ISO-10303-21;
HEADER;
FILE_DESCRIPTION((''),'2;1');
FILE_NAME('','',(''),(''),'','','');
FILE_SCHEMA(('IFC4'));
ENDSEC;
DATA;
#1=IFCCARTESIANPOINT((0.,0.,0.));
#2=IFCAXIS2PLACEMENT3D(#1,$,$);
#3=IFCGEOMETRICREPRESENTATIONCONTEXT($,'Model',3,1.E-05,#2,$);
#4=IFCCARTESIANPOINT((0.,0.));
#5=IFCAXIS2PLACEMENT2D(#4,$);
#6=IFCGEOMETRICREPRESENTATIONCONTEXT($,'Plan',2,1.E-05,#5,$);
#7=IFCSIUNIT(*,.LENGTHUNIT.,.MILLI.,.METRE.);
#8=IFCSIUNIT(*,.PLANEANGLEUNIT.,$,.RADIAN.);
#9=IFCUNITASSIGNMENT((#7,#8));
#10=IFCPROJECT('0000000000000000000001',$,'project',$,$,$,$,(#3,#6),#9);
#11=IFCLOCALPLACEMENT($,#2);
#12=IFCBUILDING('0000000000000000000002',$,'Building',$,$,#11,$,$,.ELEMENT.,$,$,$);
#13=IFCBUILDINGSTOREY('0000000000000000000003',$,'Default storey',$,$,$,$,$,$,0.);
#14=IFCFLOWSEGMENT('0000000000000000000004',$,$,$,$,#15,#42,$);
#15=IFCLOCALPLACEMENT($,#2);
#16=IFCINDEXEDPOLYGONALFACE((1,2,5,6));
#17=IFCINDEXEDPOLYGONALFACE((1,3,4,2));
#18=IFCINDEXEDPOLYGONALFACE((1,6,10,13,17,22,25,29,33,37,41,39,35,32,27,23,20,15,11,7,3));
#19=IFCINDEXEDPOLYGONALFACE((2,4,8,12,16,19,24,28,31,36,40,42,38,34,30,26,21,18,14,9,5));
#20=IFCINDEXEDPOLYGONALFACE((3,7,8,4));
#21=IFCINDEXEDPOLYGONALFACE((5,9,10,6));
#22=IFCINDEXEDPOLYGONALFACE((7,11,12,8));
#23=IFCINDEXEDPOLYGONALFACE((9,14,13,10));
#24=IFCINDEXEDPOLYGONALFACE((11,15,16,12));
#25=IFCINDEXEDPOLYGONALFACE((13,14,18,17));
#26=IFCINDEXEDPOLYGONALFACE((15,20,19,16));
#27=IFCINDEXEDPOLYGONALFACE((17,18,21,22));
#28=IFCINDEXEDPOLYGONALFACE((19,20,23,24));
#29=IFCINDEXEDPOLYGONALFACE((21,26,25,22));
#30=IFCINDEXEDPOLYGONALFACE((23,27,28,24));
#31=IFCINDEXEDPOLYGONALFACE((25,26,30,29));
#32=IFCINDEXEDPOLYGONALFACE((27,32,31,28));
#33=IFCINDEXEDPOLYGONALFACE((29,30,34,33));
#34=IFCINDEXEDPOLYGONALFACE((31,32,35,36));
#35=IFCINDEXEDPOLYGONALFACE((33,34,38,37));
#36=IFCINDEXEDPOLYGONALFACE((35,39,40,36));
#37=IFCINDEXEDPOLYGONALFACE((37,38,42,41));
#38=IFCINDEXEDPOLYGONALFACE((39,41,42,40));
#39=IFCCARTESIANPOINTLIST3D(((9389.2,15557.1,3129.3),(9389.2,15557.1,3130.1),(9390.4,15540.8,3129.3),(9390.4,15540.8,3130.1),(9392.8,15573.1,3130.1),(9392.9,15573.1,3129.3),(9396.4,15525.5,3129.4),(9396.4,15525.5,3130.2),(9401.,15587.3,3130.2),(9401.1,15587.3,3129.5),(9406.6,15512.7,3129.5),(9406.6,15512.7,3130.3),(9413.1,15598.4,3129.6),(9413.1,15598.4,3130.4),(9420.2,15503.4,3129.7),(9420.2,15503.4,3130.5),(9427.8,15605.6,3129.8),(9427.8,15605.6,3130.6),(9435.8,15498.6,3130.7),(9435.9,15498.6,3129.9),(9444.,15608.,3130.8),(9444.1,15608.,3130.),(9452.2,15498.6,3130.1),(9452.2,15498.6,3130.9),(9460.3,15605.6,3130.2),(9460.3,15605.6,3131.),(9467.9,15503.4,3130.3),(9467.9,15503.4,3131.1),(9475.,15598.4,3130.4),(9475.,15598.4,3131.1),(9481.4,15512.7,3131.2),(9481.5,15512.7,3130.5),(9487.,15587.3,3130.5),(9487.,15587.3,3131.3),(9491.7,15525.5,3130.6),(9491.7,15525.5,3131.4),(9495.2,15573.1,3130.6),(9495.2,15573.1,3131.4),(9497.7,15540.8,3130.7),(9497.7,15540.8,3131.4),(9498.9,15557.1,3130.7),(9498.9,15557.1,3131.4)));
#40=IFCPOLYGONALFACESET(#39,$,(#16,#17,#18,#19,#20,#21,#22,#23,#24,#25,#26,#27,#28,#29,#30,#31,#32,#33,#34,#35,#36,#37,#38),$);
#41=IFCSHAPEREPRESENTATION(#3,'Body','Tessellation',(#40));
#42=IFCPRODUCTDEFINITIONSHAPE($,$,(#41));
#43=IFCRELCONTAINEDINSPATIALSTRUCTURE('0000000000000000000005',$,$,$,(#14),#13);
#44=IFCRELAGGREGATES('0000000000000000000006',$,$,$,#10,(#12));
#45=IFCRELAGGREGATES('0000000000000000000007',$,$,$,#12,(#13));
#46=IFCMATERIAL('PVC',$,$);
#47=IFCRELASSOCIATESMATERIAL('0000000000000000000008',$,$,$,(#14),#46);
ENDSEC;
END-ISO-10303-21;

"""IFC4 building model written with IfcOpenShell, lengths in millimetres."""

from ifc_helpers import new_model, si_unit, frame, origin, origin_2d, place, context, project, spatial, circle, extrude, material, element, save


model = new_model("IFC4")

# Units and contexts
model_context = context("Model", 3, precision=1e-05, world=origin())
plan_context = context("Plan", 2, precision=1e-05, world=origin_2d())
ifc_project = project(units=[si_unit("LENGTHUNIT", "METRE", prefix="MILLI"), si_unit("PLANEANGLEUNIT", "RADIAN")], contexts=[model_context, plan_context])

# Building, storey
placement = place(None, origin())
building = spatial("IfcBuilding", under=ifc_project, at=placement, Name="Building", CompositionType="ELEMENT")
storey = spatial("IfcBuildingStorey", under=building, Name="Default storey", Elevation=0.0)

# Flow segment
ifc_material = material(Name="PVC")
element("IfcFlowSegment", 1, at=placement, inside=storey, material=ifc_material, context=model_context, shape_type="SweptSolid", body=[
    extrude(circle(Radius=55.0, at=origin_2d()), frame((9444.1, 15553.0, 3130.0), z_axis=(-0.009595, 0.0, 0.767565), x_axis=(0.0, 9.594563, 0.0)), (0.0, 0.0, 1.0), 0.8),
])

save(model, "model.ifc")
